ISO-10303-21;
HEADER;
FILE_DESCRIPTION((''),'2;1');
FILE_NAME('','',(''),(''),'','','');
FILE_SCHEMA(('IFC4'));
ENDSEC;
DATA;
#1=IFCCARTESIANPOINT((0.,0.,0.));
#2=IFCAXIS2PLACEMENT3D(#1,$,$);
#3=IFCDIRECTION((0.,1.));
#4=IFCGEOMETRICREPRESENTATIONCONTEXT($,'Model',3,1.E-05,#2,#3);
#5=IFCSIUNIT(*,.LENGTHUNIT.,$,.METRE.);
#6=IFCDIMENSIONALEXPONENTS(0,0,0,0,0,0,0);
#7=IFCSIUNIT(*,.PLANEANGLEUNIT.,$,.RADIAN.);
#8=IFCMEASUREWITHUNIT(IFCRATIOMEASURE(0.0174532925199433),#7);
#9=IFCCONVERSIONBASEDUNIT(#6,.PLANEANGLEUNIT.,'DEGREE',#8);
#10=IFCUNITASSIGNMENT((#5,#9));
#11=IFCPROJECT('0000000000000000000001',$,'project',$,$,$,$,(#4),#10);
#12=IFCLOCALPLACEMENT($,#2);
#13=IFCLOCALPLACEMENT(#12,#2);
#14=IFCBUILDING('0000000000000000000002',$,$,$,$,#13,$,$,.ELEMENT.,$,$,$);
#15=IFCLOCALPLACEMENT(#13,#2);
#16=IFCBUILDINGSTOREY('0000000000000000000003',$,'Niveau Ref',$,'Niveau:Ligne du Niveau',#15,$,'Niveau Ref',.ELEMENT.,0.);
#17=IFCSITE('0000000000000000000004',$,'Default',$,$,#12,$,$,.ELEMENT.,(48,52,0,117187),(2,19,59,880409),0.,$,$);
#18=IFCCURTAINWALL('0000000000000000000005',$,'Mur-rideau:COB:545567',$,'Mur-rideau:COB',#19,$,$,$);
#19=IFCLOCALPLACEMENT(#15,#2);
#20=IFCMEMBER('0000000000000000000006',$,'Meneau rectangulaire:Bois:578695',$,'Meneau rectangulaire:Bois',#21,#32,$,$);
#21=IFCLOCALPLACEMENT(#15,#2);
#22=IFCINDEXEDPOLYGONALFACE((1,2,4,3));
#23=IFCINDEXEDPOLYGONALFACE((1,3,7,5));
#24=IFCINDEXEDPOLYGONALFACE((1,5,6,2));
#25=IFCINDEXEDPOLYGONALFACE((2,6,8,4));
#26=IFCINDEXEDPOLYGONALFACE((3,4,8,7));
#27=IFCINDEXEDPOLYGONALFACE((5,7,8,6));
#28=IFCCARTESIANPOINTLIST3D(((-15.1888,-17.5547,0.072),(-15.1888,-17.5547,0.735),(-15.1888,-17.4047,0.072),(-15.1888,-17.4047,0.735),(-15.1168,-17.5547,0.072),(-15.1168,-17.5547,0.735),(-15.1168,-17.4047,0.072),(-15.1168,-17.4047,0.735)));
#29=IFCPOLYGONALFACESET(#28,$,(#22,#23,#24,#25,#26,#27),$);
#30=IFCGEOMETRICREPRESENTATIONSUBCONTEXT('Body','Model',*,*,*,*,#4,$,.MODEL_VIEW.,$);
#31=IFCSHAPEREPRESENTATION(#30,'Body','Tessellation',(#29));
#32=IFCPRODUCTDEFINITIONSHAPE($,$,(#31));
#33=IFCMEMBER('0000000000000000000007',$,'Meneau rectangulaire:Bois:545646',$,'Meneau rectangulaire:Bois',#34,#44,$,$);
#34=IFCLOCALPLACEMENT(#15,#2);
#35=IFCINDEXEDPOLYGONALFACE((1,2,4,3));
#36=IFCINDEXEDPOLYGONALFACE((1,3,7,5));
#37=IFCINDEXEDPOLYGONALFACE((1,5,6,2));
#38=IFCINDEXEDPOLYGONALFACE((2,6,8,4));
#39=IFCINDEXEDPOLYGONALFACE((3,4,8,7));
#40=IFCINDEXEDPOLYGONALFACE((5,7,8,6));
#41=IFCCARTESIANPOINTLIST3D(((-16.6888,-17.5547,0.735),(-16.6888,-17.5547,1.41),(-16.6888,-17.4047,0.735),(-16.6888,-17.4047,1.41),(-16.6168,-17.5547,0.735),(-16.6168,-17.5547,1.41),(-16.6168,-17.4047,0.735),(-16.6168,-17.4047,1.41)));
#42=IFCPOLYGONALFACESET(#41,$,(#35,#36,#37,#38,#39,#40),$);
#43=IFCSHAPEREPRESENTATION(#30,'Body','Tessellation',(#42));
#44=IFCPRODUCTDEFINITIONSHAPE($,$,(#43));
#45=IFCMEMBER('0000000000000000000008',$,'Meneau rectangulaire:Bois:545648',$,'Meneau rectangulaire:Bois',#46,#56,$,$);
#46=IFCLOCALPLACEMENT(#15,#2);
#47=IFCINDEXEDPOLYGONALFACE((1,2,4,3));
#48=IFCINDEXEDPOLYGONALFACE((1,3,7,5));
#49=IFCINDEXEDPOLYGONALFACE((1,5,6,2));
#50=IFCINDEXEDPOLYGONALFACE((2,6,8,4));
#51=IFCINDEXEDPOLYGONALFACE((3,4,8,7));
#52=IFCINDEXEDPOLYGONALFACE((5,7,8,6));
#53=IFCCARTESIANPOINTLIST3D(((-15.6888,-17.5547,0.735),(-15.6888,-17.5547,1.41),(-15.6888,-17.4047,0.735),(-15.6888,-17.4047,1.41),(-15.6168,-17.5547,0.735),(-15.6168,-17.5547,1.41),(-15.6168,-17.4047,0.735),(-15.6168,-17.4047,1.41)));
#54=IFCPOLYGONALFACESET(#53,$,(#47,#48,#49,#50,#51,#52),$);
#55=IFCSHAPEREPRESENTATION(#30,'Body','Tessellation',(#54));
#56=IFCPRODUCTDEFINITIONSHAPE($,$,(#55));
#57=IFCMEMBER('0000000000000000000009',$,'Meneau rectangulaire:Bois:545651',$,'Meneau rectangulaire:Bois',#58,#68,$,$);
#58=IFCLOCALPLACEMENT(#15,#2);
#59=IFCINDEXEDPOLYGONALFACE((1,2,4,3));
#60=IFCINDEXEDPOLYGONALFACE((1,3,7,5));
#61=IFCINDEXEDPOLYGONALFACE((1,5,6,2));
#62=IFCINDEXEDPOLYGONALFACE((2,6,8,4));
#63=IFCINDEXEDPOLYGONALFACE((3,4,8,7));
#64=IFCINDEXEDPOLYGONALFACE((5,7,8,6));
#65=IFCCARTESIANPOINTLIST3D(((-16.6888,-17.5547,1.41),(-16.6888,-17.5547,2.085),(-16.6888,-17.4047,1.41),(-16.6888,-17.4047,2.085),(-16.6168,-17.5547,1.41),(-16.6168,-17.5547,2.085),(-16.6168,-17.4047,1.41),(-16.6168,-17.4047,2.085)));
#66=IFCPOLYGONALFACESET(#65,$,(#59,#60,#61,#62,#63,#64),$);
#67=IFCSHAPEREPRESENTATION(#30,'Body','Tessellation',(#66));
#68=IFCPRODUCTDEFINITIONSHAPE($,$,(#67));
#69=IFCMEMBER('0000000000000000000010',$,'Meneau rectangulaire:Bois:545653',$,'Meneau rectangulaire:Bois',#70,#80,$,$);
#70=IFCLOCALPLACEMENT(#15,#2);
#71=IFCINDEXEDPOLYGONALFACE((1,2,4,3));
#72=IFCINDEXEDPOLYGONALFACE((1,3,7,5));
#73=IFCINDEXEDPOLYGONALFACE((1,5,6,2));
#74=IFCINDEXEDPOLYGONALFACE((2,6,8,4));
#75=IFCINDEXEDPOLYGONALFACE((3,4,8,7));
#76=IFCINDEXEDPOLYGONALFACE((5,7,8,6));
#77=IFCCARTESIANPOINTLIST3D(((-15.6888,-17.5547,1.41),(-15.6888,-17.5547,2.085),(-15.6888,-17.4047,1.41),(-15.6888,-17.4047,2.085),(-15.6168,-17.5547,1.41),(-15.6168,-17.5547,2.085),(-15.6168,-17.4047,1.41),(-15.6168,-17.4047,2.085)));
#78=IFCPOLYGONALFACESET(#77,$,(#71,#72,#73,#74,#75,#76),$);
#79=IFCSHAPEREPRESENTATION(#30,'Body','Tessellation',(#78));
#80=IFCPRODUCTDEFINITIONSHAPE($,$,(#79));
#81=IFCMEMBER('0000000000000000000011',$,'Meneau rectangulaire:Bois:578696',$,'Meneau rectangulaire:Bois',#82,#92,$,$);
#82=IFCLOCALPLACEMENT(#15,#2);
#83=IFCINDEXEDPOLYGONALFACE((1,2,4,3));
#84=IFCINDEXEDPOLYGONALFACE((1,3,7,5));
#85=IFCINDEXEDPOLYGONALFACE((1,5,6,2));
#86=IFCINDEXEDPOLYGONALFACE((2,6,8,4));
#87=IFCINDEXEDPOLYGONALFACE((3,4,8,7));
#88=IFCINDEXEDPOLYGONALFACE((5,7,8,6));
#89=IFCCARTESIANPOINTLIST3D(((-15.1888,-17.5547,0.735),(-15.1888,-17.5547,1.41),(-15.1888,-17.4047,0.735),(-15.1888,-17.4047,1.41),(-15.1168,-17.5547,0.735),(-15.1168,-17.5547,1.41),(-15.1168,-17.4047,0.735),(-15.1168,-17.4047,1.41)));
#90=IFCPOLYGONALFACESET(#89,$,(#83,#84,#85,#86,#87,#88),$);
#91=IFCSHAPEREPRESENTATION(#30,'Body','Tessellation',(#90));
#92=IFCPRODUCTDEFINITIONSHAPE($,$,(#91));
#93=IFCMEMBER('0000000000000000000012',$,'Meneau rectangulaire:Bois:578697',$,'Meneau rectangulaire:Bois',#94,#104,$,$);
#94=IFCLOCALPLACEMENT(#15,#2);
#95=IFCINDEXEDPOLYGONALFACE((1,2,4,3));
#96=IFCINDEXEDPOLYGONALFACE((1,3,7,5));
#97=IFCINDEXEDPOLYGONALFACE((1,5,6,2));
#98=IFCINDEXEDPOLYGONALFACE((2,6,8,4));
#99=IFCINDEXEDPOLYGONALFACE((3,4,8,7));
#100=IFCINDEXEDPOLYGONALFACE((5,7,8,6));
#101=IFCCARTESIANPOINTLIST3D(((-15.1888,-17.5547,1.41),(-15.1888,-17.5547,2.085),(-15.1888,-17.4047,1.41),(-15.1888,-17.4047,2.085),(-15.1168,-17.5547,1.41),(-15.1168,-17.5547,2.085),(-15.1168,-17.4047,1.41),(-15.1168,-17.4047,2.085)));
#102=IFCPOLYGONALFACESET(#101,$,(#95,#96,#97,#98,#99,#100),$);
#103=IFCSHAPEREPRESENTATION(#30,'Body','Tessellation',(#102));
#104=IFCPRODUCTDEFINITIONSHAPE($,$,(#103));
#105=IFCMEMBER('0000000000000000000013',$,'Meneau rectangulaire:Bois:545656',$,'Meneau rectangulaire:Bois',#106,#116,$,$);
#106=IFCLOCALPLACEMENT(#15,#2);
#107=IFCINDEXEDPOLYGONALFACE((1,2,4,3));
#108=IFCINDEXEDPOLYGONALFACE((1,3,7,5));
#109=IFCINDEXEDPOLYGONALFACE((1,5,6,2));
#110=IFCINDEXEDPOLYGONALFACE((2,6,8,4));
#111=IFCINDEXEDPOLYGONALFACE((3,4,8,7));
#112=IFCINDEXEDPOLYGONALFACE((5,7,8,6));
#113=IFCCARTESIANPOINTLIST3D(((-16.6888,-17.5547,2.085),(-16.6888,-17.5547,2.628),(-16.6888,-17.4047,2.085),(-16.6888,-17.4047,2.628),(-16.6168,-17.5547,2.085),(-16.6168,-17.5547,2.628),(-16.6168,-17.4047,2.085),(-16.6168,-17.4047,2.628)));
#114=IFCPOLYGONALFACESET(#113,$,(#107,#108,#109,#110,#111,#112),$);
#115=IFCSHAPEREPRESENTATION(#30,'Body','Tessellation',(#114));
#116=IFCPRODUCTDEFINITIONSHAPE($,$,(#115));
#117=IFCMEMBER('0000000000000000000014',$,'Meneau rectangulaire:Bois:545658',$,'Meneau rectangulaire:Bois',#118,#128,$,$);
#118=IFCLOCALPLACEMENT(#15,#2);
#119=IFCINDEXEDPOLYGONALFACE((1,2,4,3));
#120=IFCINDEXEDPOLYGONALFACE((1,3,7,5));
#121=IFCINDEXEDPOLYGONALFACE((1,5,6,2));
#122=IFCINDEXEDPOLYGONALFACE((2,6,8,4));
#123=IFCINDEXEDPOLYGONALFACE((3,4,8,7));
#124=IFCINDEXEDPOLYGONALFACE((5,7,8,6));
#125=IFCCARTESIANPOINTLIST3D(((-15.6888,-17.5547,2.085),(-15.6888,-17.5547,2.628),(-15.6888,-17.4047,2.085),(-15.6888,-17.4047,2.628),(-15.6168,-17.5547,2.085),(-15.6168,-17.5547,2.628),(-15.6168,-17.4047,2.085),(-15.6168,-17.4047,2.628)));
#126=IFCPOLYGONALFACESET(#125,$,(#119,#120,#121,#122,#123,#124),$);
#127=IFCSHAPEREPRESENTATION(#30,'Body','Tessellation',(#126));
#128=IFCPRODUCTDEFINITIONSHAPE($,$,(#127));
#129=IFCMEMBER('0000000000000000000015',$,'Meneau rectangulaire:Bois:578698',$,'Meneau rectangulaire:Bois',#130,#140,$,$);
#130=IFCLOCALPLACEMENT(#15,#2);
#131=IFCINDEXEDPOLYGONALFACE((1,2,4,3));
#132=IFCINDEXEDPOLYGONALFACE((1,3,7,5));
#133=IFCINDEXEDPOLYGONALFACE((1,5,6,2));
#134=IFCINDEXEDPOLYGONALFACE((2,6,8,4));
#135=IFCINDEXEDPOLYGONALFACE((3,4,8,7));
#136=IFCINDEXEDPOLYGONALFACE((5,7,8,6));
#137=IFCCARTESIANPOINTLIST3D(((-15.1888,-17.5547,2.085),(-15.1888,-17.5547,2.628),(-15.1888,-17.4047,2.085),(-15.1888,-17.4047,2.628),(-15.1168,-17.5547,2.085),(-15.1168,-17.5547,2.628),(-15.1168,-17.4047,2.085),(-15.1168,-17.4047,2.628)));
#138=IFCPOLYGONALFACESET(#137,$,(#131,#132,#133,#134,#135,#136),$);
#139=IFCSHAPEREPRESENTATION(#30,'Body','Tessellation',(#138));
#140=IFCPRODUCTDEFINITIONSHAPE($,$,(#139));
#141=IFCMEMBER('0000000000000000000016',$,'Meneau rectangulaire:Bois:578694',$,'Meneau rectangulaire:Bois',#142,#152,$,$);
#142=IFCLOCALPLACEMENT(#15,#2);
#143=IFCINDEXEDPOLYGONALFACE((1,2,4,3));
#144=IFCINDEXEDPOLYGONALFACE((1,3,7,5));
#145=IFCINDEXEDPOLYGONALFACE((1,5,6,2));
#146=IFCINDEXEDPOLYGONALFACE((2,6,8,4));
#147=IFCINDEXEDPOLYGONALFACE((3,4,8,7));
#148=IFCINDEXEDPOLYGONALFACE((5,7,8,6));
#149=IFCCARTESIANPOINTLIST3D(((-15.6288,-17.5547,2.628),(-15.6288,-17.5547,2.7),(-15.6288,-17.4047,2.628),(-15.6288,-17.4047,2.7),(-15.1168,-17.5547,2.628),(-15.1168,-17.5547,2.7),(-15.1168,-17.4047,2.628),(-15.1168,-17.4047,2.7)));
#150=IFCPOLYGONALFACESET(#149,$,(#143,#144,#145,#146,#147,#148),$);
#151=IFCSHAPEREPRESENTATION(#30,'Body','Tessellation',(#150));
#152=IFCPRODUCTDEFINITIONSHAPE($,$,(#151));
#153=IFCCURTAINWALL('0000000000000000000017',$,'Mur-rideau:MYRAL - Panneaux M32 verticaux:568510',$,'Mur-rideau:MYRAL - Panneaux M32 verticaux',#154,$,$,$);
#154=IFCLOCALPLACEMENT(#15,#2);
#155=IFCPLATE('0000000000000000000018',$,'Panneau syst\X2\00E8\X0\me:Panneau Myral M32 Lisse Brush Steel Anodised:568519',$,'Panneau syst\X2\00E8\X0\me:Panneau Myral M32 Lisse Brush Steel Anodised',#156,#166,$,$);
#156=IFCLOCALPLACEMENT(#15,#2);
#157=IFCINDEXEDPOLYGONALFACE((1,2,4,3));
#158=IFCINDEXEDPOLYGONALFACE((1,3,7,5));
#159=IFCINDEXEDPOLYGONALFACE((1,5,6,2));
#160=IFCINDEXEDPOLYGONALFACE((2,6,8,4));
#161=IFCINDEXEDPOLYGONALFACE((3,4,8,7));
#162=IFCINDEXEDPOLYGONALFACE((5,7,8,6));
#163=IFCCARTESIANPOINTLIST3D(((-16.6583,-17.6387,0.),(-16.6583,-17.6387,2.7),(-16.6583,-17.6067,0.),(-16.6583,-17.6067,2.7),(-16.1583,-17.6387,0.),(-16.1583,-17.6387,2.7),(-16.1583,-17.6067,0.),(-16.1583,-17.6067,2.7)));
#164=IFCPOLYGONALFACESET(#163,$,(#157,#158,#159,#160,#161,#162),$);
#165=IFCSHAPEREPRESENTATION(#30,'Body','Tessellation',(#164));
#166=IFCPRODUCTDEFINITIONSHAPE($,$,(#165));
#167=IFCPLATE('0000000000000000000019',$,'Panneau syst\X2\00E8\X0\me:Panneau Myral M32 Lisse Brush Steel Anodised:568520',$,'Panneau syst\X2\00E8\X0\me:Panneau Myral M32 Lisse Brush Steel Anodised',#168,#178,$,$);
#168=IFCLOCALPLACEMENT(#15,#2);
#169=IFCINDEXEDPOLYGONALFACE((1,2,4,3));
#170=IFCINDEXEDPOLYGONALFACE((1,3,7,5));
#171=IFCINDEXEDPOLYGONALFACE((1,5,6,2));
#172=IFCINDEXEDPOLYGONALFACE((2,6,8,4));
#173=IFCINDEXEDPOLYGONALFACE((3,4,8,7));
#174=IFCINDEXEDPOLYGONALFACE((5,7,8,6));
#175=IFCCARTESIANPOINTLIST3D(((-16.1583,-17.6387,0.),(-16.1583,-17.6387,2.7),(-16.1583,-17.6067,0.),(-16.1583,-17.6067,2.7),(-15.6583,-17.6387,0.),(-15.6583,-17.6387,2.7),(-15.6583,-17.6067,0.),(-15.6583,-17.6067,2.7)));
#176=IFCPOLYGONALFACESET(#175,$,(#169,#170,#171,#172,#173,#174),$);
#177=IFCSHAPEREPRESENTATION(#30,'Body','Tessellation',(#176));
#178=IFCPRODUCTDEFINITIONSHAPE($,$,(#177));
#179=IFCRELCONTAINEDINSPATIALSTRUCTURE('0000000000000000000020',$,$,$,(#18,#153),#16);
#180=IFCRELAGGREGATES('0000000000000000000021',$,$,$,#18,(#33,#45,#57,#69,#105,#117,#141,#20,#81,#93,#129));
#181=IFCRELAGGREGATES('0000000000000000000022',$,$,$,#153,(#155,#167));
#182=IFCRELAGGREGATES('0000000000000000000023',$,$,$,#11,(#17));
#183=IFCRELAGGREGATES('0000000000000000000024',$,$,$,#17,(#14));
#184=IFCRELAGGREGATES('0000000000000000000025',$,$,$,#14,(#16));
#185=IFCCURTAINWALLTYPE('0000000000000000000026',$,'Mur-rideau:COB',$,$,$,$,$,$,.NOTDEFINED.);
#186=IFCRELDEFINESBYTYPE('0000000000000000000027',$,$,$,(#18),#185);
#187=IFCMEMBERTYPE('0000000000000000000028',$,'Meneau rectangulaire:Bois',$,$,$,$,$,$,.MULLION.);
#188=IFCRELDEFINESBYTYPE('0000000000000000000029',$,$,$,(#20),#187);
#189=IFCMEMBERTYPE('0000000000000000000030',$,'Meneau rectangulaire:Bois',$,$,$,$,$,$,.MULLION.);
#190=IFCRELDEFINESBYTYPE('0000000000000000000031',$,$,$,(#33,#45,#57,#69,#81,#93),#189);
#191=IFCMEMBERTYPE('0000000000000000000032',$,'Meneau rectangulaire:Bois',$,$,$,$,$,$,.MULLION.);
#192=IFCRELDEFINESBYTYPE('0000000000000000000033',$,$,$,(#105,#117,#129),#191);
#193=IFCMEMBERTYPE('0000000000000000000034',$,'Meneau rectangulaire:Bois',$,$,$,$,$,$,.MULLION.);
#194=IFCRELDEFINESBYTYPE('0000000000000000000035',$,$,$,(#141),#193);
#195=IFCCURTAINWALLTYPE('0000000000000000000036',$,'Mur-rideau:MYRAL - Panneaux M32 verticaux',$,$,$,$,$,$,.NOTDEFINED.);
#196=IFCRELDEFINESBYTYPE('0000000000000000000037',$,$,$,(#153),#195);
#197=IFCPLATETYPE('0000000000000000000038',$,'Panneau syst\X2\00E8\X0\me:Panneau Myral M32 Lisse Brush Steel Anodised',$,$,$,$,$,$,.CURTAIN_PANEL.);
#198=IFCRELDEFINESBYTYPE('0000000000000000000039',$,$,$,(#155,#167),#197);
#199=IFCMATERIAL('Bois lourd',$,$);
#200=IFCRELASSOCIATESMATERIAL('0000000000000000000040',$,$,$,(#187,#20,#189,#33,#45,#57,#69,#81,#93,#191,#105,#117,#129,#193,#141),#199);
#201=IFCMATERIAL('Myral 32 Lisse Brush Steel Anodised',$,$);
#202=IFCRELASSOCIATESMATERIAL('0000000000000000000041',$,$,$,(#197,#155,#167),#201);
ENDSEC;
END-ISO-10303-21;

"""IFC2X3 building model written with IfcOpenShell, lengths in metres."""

from ifc_helpers import new_model, entity, si_unit, converted_unit, direction, frame, origin, origin_2d_with_axis, place, context, subcontext, project, spatial, rectangle, extrude, source, transform, mapped, material, type_object, type_shapes, element, aggregate, save


model = new_model("IFC2X3")

# Units and contexts
model_context = context("Model", 3, precision=1e-05, world=origin(), true_north=direction((0.0, 1.0)))
body_context = subcontext(model_context, "Body", "Model", "MODEL_VIEW")
ifc_project = project(units=[si_unit("LENGTHUNIT", "METRE"), converted_unit("PLANEANGLEUNIT", "DEGREE", entity("IfcRatioMeasure", 0.0174532925199433), si_unit("PLANEANGLEUNIT", "RADIAN"), dimensions=[0, 0, 0, 0, 0, 0, 0])], contexts=[model_context])

# Site, building, storey
site_placement = place(None, origin())
site = spatial("IfcSite", under=ifc_project, at=site_placement, Name="Default", CompositionType="ELEMENT", RefLatitude=(48, 52, 0, 117187), RefLongitude=(2, 19, 59, 880409), RefElevation=0.0)
building_placement = place(site_placement, origin())
building = spatial("IfcBuilding", under=site, at=building_placement, CompositionType="ELEMENT")
storey_placement = place(building_placement, origin())
storey = spatial("IfcBuildingStorey", under=building, at=storey_placement, Name="Niveau Ref", ObjectType="Niveau:Ligne du Niveau", LongName="Niveau Ref", CompositionType="ELEMENT", Elevation=0.0)

# Curtain wall, members
curtain_wall_type_1 = type_object("IfcCurtainWallType", Name="Mur-rideau:COB", PredefinedType="NOTDEFINED")
curtain_wall_1_placement = place(storey_placement, origin())
curtain_wall_1 = element("IfcCurtainWall", 1, at=curtain_wall_1_placement, inside=storey, type_object=curtain_wall_type_1, Name="Mur-rideau:COB:545567", ObjectType="Mur-rideau:COB")
ifc_material_1 = material(Name="Bois lourd")
member_type_1 = type_object("IfcMemberType", Name="Meneau rectangulaire:Bois", PredefinedType="MULLION", material=ifc_material_1)
shared_shape_1 = source(origin(), body_context, "Body", "SweptSolid", [
    extrude(rectangle(XDim=0.15, YDim=0.072, at=origin_2d_with_axis()), frame((-0.024, 0.0, -0.663), z_axis=(0.0, 0.0, 1.0), x_axis=(0.0, -1.0, 0.0)), (0.0, 0.0, 1.0), 0.663),
])
type_shapes(member_type_1, [shared_shape_1])
member_1_placement = place(storey_placement, frame((-15.1288, -17.4797, 0.072), z_axis=(0.0, 0.0, -1.0), x_axis=(1.0, 0.0, 0.0)))
member_1 = element("IfcMember", 2, at=member_1_placement, type_object=member_type_1, material=ifc_material_1, Name="Meneau rectangulaire:Bois:578695", ObjectType="Meneau rectangulaire:Bois", context=body_context, shape_type="MappedRepresentation", body=[
    mapped(shared_shape_1, transform((0.0, 0.0, 0.0), scale=1.0)),
])
member_type_2 = type_object("IfcMemberType", Name="Meneau rectangulaire:Bois", PredefinedType="MULLION", material=ifc_material_1)
shared_shape_2 = source(origin(), body_context, "Body", "SweptSolid", [
    extrude(rectangle(XDim=0.15, YDim=0.072, at=origin_2d_with_axis()), frame((-0.024, 0.0, -0.675), z_axis=(0.0, 0.0, 1.0), x_axis=(0.0, -1.0, 0.0)), (0.0, 0.0, 1.0), 0.675),
])
type_shapes(member_type_2, [shared_shape_2])
member_2_placement = place(storey_placement, frame((-16.6288, -17.4797, 0.735), z_axis=(0.0, 0.0, -1.0), x_axis=(1.0, 0.0, 0.0)))
member_2 = element("IfcMember", 3, at=member_2_placement, type_object=member_type_2, material=ifc_material_1, Name="Meneau rectangulaire:Bois:545646", ObjectType="Meneau rectangulaire:Bois", context=body_context, shape_type="MappedRepresentation", body=[
    mapped(shared_shape_2, transform((0.0, 0.0, 0.0), scale=1.0)),
])
member_3_placement = place(storey_placement, frame((-15.6288, -17.4797, 0.735), z_axis=(0.0, 0.0, -1.0), x_axis=(1.0, 0.0, 0.0)))
member_3 = element("IfcMember", 4, at=member_3_placement, type_object=member_type_2, material=ifc_material_1, Name="Meneau rectangulaire:Bois:545648", ObjectType="Meneau rectangulaire:Bois", context=body_context, shape_type="MappedRepresentation", body=[
    mapped(shared_shape_2, transform((0.0, 0.0, 0.0), scale=1.0)),
])
member_4_placement = place(storey_placement, frame((-16.6288, -17.4797, 1.41), z_axis=(0.0, 0.0, -1.0), x_axis=(1.0, 0.0, 0.0)))
member_4 = element("IfcMember", 5, at=member_4_placement, type_object=member_type_2, material=ifc_material_1, Name="Meneau rectangulaire:Bois:545651", ObjectType="Meneau rectangulaire:Bois", context=body_context, shape_type="MappedRepresentation", body=[
    mapped(shared_shape_2, transform((0.0, 0.0, 0.0), scale=1.0)),
])
member_5_placement = place(storey_placement, frame((-15.6288, -17.4797, 1.41), z_axis=(0.0, 0.0, -1.0), x_axis=(1.0, 0.0, 0.0)))
member_5 = element("IfcMember", 6, at=member_5_placement, type_object=member_type_2, material=ifc_material_1, Name="Meneau rectangulaire:Bois:545653", ObjectType="Meneau rectangulaire:Bois", context=body_context, shape_type="MappedRepresentation", body=[
    mapped(shared_shape_2, transform((0.0, 0.0, 0.0), scale=1.0)),
])
member_6_placement = place(storey_placement, frame((-15.1288, -17.4797, 0.735), z_axis=(0.0, 0.0, -1.0), x_axis=(1.0, 0.0, 0.0)))
member_6 = element("IfcMember", 7, at=member_6_placement, type_object=member_type_2, material=ifc_material_1, Name="Meneau rectangulaire:Bois:578696", ObjectType="Meneau rectangulaire:Bois", context=body_context, shape_type="MappedRepresentation", body=[
    mapped(shared_shape_2, transform((0.0, 0.0, 0.0), scale=1.0)),
])
member_7_placement = place(storey_placement, frame((-15.1288, -17.4797, 1.41), z_axis=(0.0, 0.0, -1.0), x_axis=(1.0, 0.0, 0.0)))
member_7 = element("IfcMember", 8, at=member_7_placement, type_object=member_type_2, material=ifc_material_1, Name="Meneau rectangulaire:Bois:578697", ObjectType="Meneau rectangulaire:Bois", context=body_context, shape_type="MappedRepresentation", body=[
    mapped(shared_shape_2, transform((0.0, 0.0, 0.0), scale=1.0)),
])
member_type_3 = type_object("IfcMemberType", Name="Meneau rectangulaire:Bois", PredefinedType="MULLION", material=ifc_material_1)
shared_shape_3 = source(origin(), body_context, "Body", "SweptSolid", [
    extrude(rectangle(XDim=0.15, YDim=0.072, at=origin_2d_with_axis()), frame((-0.024, 0.0, -0.543), z_axis=(0.0, 0.0, 1.0), x_axis=(0.0, -1.0, 0.0)), (0.0, 0.0, 1.0), 0.543),
])
type_shapes(member_type_3, [shared_shape_3])
member_8_placement = place(storey_placement, frame((-16.6288, -17.4797, 2.085), z_axis=(0.0, 0.0, -1.0), x_axis=(1.0, 0.0, 0.0)))
member_8 = element("IfcMember", 9, at=member_8_placement, type_object=member_type_3, material=ifc_material_1, Name="Meneau rectangulaire:Bois:545656", ObjectType="Meneau rectangulaire:Bois", context=body_context, shape_type="MappedRepresentation", body=[
    mapped(shared_shape_3, transform((0.0, 0.0, 0.0), scale=1.0)),
])
member_9_placement = place(storey_placement, frame((-15.6288, -17.4797, 2.085), z_axis=(0.0, 0.0, -1.0), x_axis=(1.0, 0.0, 0.0)))
member_9 = element("IfcMember", 10, at=member_9_placement, type_object=member_type_3, material=ifc_material_1, Name="Meneau rectangulaire:Bois:545658", ObjectType="Meneau rectangulaire:Bois", context=body_context, shape_type="MappedRepresentation", body=[
    mapped(shared_shape_3, transform((0.0, 0.0, 0.0), scale=1.0)),
])
member_10_placement = place(storey_placement, frame((-15.1288, -17.4797, 2.085), z_axis=(0.0, 0.0, -1.0), x_axis=(1.0, 0.0, 0.0)))
member_10 = element("IfcMember", 11, at=member_10_placement, type_object=member_type_3, material=ifc_material_1, Name="Meneau rectangulaire:Bois:578698", ObjectType="Meneau rectangulaire:Bois", context=body_context, shape_type="MappedRepresentation", body=[
    mapped(shared_shape_3, transform((0.0, 0.0, 0.0), scale=1.0)),
])
member_type_4 = type_object("IfcMemberType", Name="Meneau rectangulaire:Bois", PredefinedType="MULLION", material=ifc_material_1)
shared_shape_4 = source(origin(), body_context, "Body", "SweptSolid", [
    extrude(rectangle(XDim=0.15, YDim=0.072, at=origin_2d_with_axis()), frame((-0.036, 0.0, -0.512), z_axis=(0.0, 0.0, 1.0), x_axis=(0.0, -1.0, 0.0)), (0.0, 0.0, 1.0), 0.512),
])
type_shapes(member_type_4, [shared_shape_4])
member_11_placement = place(storey_placement, frame((-15.1168, -17.4797, 2.7), z_axis=(1.0, 0.0, 0.0), x_axis=(0.0, 0.0, 1.0)))
member_11 = element("IfcMember", 12, at=member_11_placement, type_object=member_type_4, material=ifc_material_1, Name="Meneau rectangulaire:Bois:578694", ObjectType="Meneau rectangulaire:Bois", context=body_context, shape_type="MappedRepresentation", body=[
    mapped(shared_shape_4, transform((0.0, 0.0, 0.0), scale=1.0)),
])
aggregate(curtain_wall_1, [member_2, member_3, member_4, member_5, member_8, member_9, member_11, member_1, member_6, member_7, member_10])

# Curtain wall, plates
curtain_wall_type_2 = type_object("IfcCurtainWallType", Name="Mur-rideau:MYRAL - Panneaux M32 verticaux", PredefinedType="NOTDEFINED")
curtain_wall_2_placement = place(storey_placement, origin())
curtain_wall_2 = element("IfcCurtainWall", 13, at=curtain_wall_2_placement, inside=storey, type_object=curtain_wall_type_2, Name="Mur-rideau:MYRAL - Panneaux M32 verticaux:568510", ObjectType="Mur-rideau:MYRAL - Panneaux M32 verticaux")
ifc_material_2 = material(Name="Myral 32 Lisse Brush Steel Anodised")
plate_type = type_object("IfcPlateType", Name="Panneau système:Panneau Myral M32 Lisse Brush Steel Anodised", PredefinedType="CURTAIN_PANEL", material=ifc_material_2)
shared_shape_5 = source(origin(), body_context, "Body", "SweptSolid", [
    extrude(rectangle(XDim=0.032, YDim=0.5, at=origin_2d_with_axis()), frame((0.0, -0.016, 0.0), z_axis=(0.0, 0.0, 1.0), x_axis=(0.0, 1.0, 0.0)), (0.0, 0.0, 1.0), 2.7),
])
type_shapes(plate_type, [shared_shape_5])
plate_1_placement = place(curtain_wall_2_placement, frame((-16.4083, -17.6067, 0.0)))
plate_1 = element("IfcPlate", 14, at=plate_1_placement, type_object=plate_type, material=ifc_material_2, Name="Panneau système:Panneau Myral M32 Lisse Brush Steel Anodised:568519", ObjectType="Panneau système:Panneau Myral M32 Lisse Brush Steel Anodised", context=body_context, shape_type="MappedRepresentation", body=[
    mapped(shared_shape_5, transform((0.0, 0.0, 0.0), scale=1.0)),
])
plate_2_placement = place(curtain_wall_2_placement, frame((-15.9083, -17.6067, 0.0)))
plate_2 = element("IfcPlate", 15, at=plate_2_placement, type_object=plate_type, material=ifc_material_2, Name="Panneau système:Panneau Myral M32 Lisse Brush Steel Anodised:568520", ObjectType="Panneau système:Panneau Myral M32 Lisse Brush Steel Anodised", context=body_context, shape_type="MappedRepresentation", body=[
    mapped(shared_shape_5, transform((0.0, 0.0, 0.0), scale=1.0)),
])
aggregate(curtain_wall_2, [plate_1, plate_2])

save(model, "model.ifc")
